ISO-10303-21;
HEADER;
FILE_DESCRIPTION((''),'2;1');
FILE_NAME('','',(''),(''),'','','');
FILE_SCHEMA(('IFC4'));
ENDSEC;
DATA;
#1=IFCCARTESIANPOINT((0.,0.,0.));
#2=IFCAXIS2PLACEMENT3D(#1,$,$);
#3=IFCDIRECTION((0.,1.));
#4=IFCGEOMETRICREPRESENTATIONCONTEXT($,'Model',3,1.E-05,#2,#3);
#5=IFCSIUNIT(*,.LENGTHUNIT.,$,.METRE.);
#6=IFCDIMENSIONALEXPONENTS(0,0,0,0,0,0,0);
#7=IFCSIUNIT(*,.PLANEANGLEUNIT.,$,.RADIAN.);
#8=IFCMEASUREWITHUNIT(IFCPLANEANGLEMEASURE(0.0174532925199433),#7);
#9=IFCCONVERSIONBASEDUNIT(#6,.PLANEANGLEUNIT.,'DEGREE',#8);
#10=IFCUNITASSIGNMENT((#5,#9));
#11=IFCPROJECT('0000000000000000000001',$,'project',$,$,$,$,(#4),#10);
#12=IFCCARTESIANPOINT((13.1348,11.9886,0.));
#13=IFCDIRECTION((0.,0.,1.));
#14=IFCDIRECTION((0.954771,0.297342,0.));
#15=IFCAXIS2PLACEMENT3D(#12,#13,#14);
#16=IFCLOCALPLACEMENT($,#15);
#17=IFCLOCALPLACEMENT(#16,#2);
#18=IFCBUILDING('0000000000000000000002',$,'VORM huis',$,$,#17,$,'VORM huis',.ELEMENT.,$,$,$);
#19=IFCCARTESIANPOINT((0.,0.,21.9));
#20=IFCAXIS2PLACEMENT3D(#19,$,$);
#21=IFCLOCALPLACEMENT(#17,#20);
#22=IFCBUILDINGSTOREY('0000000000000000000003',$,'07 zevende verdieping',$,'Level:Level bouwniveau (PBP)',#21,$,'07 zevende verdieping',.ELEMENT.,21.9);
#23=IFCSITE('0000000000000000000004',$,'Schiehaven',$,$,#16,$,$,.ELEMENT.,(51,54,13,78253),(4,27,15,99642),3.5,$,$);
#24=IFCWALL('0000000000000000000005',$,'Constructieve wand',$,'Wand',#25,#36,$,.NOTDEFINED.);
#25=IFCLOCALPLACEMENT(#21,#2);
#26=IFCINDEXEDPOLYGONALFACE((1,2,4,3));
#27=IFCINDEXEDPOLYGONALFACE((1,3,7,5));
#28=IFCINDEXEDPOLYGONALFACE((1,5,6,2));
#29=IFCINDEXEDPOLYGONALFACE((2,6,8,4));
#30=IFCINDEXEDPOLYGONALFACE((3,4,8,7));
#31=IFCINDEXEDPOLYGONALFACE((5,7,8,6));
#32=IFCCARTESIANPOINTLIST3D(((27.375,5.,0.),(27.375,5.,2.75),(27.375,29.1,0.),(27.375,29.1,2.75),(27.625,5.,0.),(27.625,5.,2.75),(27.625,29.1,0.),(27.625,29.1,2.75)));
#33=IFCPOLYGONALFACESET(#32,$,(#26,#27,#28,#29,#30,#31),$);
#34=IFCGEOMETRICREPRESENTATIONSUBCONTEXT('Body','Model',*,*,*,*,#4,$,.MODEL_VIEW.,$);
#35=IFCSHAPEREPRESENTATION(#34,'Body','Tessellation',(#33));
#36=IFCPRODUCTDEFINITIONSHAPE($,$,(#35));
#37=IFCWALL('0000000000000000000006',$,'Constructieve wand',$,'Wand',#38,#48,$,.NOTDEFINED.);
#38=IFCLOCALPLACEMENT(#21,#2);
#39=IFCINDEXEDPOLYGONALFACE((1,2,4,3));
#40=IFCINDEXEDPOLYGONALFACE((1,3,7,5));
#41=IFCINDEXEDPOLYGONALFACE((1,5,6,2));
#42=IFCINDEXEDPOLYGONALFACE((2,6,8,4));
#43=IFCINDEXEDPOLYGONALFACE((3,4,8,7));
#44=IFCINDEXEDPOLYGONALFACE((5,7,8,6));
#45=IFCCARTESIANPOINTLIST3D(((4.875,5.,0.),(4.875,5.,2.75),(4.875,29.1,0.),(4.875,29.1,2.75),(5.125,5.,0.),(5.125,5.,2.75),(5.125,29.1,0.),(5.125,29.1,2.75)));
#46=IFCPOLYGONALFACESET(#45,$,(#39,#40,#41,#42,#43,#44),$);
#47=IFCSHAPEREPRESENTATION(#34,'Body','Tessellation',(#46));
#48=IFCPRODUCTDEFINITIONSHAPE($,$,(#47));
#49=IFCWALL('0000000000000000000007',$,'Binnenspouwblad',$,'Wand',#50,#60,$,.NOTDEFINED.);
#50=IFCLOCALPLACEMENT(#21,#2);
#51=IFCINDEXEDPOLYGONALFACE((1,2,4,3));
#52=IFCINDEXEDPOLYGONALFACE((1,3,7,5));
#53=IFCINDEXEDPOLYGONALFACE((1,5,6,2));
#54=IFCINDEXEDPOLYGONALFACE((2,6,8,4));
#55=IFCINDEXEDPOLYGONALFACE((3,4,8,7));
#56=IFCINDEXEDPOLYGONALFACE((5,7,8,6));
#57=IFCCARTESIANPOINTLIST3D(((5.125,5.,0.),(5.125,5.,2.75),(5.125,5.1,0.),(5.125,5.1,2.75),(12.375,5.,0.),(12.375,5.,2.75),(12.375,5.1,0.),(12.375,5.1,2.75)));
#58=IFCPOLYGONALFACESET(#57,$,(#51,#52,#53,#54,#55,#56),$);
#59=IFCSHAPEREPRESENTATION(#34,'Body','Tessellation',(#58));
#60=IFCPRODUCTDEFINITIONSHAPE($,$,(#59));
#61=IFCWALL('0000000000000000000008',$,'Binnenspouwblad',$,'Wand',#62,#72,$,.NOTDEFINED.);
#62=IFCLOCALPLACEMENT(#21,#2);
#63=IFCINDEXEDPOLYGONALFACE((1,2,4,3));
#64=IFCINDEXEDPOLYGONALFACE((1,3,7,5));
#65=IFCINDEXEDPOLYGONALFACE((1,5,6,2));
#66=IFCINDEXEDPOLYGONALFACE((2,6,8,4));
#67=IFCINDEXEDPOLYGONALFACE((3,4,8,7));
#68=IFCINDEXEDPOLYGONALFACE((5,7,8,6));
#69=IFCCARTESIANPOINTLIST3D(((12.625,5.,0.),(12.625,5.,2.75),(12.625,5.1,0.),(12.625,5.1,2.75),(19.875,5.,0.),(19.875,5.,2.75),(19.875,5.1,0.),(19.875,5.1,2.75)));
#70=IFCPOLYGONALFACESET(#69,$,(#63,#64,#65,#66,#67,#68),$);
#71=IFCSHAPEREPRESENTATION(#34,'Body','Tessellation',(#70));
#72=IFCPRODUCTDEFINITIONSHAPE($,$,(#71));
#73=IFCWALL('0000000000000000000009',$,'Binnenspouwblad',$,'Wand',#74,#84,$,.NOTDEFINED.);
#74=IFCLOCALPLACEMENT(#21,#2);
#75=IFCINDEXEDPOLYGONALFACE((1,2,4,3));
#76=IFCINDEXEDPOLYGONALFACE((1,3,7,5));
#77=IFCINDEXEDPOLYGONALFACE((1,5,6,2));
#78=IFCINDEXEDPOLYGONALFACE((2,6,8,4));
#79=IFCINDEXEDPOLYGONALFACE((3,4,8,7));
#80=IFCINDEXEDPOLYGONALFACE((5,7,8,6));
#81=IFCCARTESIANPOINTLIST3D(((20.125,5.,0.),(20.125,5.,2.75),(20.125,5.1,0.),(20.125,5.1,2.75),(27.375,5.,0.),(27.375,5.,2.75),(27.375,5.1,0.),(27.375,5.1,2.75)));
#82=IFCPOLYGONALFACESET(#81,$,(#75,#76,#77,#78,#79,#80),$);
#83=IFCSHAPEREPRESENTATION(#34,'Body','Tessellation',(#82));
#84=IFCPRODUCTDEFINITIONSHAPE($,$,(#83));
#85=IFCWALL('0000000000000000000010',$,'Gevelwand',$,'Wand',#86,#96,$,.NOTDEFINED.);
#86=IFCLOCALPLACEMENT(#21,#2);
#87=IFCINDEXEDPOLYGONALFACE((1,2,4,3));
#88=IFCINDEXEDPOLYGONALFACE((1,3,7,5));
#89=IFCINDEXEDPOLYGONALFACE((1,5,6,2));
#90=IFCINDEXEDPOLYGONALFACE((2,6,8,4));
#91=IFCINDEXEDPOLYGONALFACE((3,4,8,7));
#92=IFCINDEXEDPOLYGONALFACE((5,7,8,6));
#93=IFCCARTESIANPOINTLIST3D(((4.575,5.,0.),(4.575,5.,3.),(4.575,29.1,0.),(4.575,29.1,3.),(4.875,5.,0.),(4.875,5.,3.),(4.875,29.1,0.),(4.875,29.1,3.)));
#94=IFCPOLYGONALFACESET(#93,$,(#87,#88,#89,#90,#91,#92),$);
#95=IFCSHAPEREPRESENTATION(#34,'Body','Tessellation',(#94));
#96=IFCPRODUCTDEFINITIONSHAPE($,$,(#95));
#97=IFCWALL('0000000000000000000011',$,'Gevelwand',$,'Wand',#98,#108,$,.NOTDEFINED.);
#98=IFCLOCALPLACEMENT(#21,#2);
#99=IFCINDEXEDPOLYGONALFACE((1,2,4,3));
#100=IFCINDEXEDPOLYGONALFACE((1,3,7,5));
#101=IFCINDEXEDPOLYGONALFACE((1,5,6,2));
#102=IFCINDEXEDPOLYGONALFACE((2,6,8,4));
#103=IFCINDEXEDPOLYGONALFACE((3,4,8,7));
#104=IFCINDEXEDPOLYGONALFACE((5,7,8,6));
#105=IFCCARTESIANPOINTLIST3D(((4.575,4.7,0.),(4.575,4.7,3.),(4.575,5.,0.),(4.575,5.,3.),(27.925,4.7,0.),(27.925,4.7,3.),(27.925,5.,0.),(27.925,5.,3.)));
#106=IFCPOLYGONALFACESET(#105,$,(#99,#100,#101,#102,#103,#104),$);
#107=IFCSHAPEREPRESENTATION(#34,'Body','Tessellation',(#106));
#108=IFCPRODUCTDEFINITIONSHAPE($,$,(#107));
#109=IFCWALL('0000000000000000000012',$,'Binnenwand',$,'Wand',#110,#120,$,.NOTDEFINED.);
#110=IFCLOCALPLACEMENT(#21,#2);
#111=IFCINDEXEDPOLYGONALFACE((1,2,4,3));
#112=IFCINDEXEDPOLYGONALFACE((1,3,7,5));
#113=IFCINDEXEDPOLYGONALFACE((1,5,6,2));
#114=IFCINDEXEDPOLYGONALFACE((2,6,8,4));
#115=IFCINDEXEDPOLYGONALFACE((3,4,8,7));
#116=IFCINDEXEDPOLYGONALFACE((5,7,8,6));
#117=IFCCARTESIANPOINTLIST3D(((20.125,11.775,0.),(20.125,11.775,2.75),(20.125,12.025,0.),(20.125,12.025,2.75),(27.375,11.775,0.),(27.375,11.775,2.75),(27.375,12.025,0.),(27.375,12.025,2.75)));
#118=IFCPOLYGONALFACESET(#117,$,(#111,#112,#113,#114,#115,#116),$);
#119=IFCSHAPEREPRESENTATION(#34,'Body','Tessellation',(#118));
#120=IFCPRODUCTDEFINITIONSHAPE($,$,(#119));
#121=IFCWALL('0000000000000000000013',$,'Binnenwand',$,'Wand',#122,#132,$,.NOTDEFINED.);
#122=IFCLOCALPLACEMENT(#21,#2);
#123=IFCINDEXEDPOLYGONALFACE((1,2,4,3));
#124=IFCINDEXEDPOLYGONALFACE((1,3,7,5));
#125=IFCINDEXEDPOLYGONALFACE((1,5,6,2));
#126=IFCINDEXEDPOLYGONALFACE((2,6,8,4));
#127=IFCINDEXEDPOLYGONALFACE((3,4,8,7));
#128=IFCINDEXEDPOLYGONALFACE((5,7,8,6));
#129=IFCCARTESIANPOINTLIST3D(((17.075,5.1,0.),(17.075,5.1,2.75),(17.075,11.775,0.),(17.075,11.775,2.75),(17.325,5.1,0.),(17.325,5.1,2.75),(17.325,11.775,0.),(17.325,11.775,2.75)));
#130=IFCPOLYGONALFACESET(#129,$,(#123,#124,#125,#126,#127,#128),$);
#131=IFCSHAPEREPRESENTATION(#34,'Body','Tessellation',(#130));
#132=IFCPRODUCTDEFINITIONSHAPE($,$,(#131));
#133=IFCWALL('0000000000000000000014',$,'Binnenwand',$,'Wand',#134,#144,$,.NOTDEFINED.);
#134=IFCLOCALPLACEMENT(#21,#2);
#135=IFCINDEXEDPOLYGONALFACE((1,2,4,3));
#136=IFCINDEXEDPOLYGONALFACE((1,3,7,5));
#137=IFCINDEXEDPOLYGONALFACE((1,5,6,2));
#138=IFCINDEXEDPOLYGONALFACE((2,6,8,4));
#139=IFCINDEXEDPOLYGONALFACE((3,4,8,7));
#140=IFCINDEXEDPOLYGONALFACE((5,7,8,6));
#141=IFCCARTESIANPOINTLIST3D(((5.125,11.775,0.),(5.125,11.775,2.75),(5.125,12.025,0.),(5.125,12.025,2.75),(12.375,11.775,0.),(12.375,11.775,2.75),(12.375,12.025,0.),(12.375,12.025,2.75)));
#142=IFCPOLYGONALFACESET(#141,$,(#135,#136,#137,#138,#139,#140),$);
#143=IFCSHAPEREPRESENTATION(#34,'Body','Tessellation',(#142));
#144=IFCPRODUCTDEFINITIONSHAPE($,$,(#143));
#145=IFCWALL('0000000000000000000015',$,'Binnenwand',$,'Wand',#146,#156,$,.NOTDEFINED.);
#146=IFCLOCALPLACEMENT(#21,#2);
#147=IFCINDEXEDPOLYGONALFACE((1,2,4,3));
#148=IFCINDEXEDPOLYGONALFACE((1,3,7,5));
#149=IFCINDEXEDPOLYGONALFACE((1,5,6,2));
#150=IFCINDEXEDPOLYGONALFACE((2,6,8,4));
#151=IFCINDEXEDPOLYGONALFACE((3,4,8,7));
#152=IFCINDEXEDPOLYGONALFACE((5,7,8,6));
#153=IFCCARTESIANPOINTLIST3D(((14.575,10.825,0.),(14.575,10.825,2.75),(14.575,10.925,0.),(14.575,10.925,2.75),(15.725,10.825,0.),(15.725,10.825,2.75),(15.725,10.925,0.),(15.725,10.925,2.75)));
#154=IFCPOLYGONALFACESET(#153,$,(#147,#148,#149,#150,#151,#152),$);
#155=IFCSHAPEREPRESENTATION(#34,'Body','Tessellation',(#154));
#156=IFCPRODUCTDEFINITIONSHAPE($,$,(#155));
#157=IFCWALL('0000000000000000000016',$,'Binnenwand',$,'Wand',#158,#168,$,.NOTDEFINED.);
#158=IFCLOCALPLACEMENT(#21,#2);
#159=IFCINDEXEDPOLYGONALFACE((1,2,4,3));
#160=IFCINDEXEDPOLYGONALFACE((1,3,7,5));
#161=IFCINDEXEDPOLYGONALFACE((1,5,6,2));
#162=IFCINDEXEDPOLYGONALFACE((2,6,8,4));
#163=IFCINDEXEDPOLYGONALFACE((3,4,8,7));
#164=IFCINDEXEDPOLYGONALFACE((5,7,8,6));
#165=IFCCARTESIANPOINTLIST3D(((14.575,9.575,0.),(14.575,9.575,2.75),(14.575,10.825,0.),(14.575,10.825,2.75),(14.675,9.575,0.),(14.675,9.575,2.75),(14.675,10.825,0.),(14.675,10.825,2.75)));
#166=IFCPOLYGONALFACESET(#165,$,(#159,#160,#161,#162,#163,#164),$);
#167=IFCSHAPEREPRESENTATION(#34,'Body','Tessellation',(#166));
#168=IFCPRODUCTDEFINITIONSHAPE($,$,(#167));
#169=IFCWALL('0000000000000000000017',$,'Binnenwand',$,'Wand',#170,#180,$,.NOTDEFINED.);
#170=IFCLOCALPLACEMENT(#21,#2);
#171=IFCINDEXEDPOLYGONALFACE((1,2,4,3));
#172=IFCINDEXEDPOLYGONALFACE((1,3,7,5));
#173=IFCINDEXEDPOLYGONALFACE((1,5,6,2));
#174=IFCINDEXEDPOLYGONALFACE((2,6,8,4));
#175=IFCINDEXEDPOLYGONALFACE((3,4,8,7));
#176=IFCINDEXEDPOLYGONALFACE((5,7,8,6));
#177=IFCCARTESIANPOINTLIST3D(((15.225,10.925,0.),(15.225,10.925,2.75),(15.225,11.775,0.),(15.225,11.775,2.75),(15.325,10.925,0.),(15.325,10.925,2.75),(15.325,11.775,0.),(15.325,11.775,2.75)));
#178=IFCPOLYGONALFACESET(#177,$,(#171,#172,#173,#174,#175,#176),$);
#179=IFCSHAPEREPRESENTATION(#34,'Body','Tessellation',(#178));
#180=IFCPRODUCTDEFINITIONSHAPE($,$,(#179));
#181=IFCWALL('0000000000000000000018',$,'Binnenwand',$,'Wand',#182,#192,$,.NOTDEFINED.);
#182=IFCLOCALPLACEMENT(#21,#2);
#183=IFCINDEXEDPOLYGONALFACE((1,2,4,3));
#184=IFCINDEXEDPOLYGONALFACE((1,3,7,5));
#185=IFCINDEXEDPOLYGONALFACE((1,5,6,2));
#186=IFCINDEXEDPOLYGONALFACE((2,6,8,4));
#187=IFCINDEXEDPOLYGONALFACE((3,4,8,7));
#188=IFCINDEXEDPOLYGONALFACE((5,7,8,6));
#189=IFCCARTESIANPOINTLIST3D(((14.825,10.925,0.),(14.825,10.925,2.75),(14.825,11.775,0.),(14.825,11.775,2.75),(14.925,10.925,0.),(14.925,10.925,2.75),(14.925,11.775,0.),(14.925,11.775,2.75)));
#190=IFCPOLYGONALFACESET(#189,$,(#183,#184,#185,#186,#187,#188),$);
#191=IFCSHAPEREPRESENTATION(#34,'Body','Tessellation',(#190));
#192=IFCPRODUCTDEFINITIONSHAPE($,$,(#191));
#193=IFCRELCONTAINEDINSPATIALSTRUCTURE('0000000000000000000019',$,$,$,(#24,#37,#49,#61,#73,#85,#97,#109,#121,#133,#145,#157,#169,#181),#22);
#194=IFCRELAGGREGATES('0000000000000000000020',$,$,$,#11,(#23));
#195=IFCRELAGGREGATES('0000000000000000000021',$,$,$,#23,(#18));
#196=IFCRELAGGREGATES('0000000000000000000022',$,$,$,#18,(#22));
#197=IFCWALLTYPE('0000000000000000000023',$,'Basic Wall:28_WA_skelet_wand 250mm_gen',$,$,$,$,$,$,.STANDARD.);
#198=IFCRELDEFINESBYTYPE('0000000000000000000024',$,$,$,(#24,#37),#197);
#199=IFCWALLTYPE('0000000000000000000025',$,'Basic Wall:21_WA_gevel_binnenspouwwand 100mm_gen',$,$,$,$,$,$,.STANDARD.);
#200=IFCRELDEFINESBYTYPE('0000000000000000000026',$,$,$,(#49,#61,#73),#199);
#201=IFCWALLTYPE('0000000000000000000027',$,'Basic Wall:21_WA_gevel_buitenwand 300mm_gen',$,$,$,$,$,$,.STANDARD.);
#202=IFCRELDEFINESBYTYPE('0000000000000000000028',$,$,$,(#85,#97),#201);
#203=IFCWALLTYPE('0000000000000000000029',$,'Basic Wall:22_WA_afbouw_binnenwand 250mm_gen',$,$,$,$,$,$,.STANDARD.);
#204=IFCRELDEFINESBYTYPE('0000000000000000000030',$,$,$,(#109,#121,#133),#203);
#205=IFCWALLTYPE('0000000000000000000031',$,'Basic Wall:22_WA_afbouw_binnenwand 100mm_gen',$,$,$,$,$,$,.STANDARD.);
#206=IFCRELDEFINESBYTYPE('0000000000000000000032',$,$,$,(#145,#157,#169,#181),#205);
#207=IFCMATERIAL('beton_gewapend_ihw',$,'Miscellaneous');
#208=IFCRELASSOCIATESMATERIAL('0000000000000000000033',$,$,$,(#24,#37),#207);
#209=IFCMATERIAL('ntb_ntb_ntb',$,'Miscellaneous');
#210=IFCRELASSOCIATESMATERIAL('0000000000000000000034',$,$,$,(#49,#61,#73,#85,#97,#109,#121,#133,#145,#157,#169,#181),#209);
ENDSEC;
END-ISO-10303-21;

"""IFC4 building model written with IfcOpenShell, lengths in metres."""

from ifc_helpers import new_model, entity, si_unit, converted_unit, direction, frame, origin, place, context, subcontext, project, spatial, indexed_curve, outline, extrude, material, type_object, element, save


model = new_model("IFC4")

# Units and contexts
model_context = context("Model", 3, precision=1e-05, world=origin(), true_north=direction((0.0, 1.0)))
body_context = subcontext(model_context, "Body", "Model", "MODEL_VIEW")
ifc_project = project(units=[si_unit("LENGTHUNIT", "METRE"), converted_unit("PLANEANGLEUNIT", "DEGREE", entity("IfcPlaneAngleMeasure", 0.0174532925199433), si_unit("PLANEANGLEUNIT", "RADIAN"), dimensions=[0, 0, 0, 0, 0, 0, 0])], contexts=[model_context])

# Site, building, storey
site_placement = place(None, frame((13.1348, 11.9886, 0.0), z_axis=(0.0, 0.0, 1.0), x_axis=(0.954771, 0.297342, 0.0)))
site = spatial("IfcSite", under=ifc_project, at=site_placement, Name="Schiehaven", CompositionType="ELEMENT", RefLatitude=(51, 54, 13, 78253), RefLongitude=(4, 27, 15, 99642), RefElevation=3.5)
building_placement = place(site_placement, origin())
building = spatial("IfcBuilding", under=site, at=building_placement, Name="VORM huis", LongName="VORM huis", CompositionType="ELEMENT")
storey_placement = place(building_placement, frame((0.0, 0.0, 21.9)))
storey = spatial("IfcBuildingStorey", under=building, at=storey_placement, Name="07 zevende verdieping", ObjectType="Level:Level bouwniveau (PBP)", LongName="07 zevende verdieping", CompositionType="ELEMENT", Elevation=21.9)

# Shared definitions
ifc_material_1 = material(Name="beton_gewapend_ihw", Category="Miscellaneous")

# Walls
wall_type_1 = type_object("IfcWallType", Name="Basic Wall:28_WA_skelet_wand 250mm_gen", PredefinedType="STANDARD")
wall_1_placement = place(storey_placement, frame((27.5, 5.0, 0.0), z_axis=(0.0, 0.0, 1.0), x_axis=(0.0, 1.0, 0.0)))
element("IfcWall", 1, at=wall_1_placement, inside=storey, type_object=wall_type_1, material=ifc_material_1, Name="Constructieve wand", ObjectType="Wand", PredefinedType="NOTDEFINED", context=body_context, shape_type="SweptSolid", body=[
    extrude(outline(indexed_curve([(24.1, 0.125), (0.0, 0.125), (0.0, -0.125), (24.1, -0.125), (24.1, 0.125)], self_intersect=False)), origin(), (0.0, 0.0, 1.0), 2.75),
])
wall_2_placement = place(storey_placement, frame((5.0, 5.0, 0.0), z_axis=(0.0, 0.0, 1.0), x_axis=(0.0, 1.0, 0.0)))
element("IfcWall", 2, at=wall_2_placement, inside=storey, type_object=wall_type_1, material=ifc_material_1, Name="Constructieve wand", ObjectType="Wand", PredefinedType="NOTDEFINED", context=body_context, shape_type="SweptSolid", body=[
    extrude(outline(indexed_curve([(24.1, 0.125), (0.0, 0.125), (0.0, -0.125), (24.1, -0.125), (24.1, 0.125)], self_intersect=False)), origin(), (0.0, 0.0, 1.0), 2.75),
])
ifc_material_2 = material(Name="ntb_ntb_ntb", Category="Miscellaneous")
wall_type_2 = type_object("IfcWallType", Name="Basic Wall:21_WA_gevel_binnenspouwwand 100mm_gen", PredefinedType="STANDARD")
wall_3_placement = place(storey_placement, frame((5.125, 5.05, 0.0)))
element("IfcWall", 3, at=wall_3_placement, inside=storey, type_object=wall_type_2, material=ifc_material_2, Name="Binnenspouwblad", ObjectType="Wand", PredefinedType="NOTDEFINED", context=body_context, shape_type="SweptSolid", body=[
    extrude(outline(indexed_curve([(7.25, 0.05), (0.0, 0.05), (0.0, -0.05), (7.25, -0.05), (7.25, 0.05)], self_intersect=False)), origin(), (0.0, 0.0, 1.0), 2.75),
])
wall_4_placement = place(storey_placement, frame((19.875, 5.05, 0.0), z_axis=(0.0, 0.0, 1.0), x_axis=(-1.0, 0.0, 0.0)))
element("IfcWall", 4, at=wall_4_placement, inside=storey, type_object=wall_type_2, material=ifc_material_2, Name="Binnenspouwblad", ObjectType="Wand", PredefinedType="NOTDEFINED", context=body_context, shape_type="SweptSolid", body=[
    extrude(outline(indexed_curve([(7.25, 0.05), (0.0, 0.05), (0.0, -0.05), (7.25, -0.05), (7.25, 0.05)], self_intersect=False)), origin(), (0.0, 0.0, 1.0), 2.75),
])
wall_5_placement = place(storey_placement, frame((20.125, 5.05, 0.0)))
element("IfcWall", 5, at=wall_5_placement, inside=storey, type_object=wall_type_2, material=ifc_material_2, Name="Binnenspouwblad", ObjectType="Wand", PredefinedType="NOTDEFINED", context=body_context, shape_type="SweptSolid", body=[
    extrude(outline(indexed_curve([(7.25, 0.05), (0.0, 0.05), (0.0, -0.05), (7.25, -0.05), (7.25, 0.05)], self_intersect=False)), origin(), (0.0, 0.0, 1.0), 2.75),
])
wall_type_3 = type_object("IfcWallType", Name="Basic Wall:21_WA_gevel_buitenwand 300mm_gen", PredefinedType="STANDARD")
wall_6_placement = place(storey_placement, frame((4.725, 5.0, 0.0), z_axis=(0.0, 0.0, 1.0), x_axis=(0.0, 1.0, 0.0)))
element("IfcWall", 6, at=wall_6_placement, inside=storey, type_object=wall_type_3, material=ifc_material_2, Name="Gevelwand", ObjectType="Wand", PredefinedType="NOTDEFINED", context=body_context, shape_type="SweptSolid", body=[
    extrude(outline(indexed_curve([(24.1, 0.15), (0.0, 0.15), (0.0, -0.15), (24.1, -0.15), (24.1, 0.15)], self_intersect=False)), origin(), (0.0, 0.0, 1.0), 3.0),
])
wall_7_placement = place(storey_placement, frame((27.925, 4.85, 0.0), z_axis=(0.0, 0.0, 1.0), x_axis=(-1.0, 0.0, 0.0)))
element("IfcWall", 7, at=wall_7_placement, inside=storey, type_object=wall_type_3, material=ifc_material_2, Name="Gevelwand", ObjectType="Wand", PredefinedType="NOTDEFINED", context=body_context, shape_type="SweptSolid", body=[
    extrude(outline(indexed_curve([(23.35, 0.15), (0.0, 0.15), (0.0, -0.15), (23.35, -0.15), (23.35, 0.15)], self_intersect=False)), origin(), (0.0, 0.0, 1.0), 3.0),
])
wall_type_4 = type_object("IfcWallType", Name="Basic Wall:22_WA_afbouw_binnenwand 250mm_gen", PredefinedType="STANDARD")
wall_8_placement = place(storey_placement, frame((20.125, 11.9, 0.0)))
element("IfcWall", 8, at=wall_8_placement, inside=storey, type_object=wall_type_4, material=ifc_material_2, Name="Binnenwand", ObjectType="Wand", PredefinedType="NOTDEFINED", context=body_context, shape_type="SweptSolid", body=[
    extrude(outline(indexed_curve([(7.25, 0.125), (0.0, 0.125), (0.0, -0.125), (7.25, -0.125), (7.25, 0.125)], self_intersect=False)), origin(), (0.0, 0.0, 1.0), 2.75),
])
wall_9_placement = place(storey_placement, frame((17.2, 11.775, 0.0), z_axis=(0.0, 0.0, 1.0), x_axis=(0.0, -1.0, 0.0)))
element("IfcWall", 9, at=wall_9_placement, inside=storey, type_object=wall_type_4, material=ifc_material_2, Name="Binnenwand", ObjectType="Wand", PredefinedType="NOTDEFINED", context=body_context, shape_type="SweptSolid", body=[
    extrude(outline(indexed_curve([(6.675, 0.125), (0.0, 0.125), (0.0, -0.125), (6.675, -0.125), (6.675, 0.125)], self_intersect=False)), origin(), (0.0, 0.0, 1.0), 2.75),
])
wall_10_placement = place(storey_placement, frame((12.375, 11.9, 0.0), z_axis=(0.0, 0.0, 1.0), x_axis=(-1.0, 0.0, 0.0)))
element("IfcWall", 10, at=wall_10_placement, inside=storey, type_object=wall_type_4, material=ifc_material_2, Name="Binnenwand", ObjectType="Wand", PredefinedType="NOTDEFINED", context=body_context, shape_type="SweptSolid", body=[
    extrude(outline(indexed_curve([(7.25, 0.125), (0.0, 0.125), (0.0, -0.125), (7.25, -0.125), (7.25, 0.125)], self_intersect=False)), origin(), (0.0, 0.0, 1.0), 2.75),
])
wall_type_5 = type_object("IfcWallType", Name="Basic Wall:22_WA_afbouw_binnenwand 100mm_gen", PredefinedType="STANDARD")
wall_11_placement = place(storey_placement, frame((14.575, 10.875, 0.0)))
element("IfcWall", 11, at=wall_11_placement, inside=storey, type_object=wall_type_5, material=ifc_material_2, Name="Binnenwand", ObjectType="Wand", PredefinedType="NOTDEFINED", context=body_context, shape_type="SweptSolid", body=[
    extrude(outline(indexed_curve([(1.15, 0.05), (0.0, 0.05), (0.0, -0.05), (1.15, -0.05), (1.15, 0.05)], self_intersect=False)), origin(), (0.0, 0.0, 1.0), 2.75),
])
wall_12_placement = place(storey_placement, frame((14.625, 10.825, 0.0), z_axis=(0.0, 0.0, 1.0), x_axis=(0.0, -1.0, 0.0)))
element("IfcWall", 12, at=wall_12_placement, inside=storey, type_object=wall_type_5, material=ifc_material_2, Name="Binnenwand", ObjectType="Wand", PredefinedType="NOTDEFINED", context=body_context, shape_type="SweptSolid", body=[
    extrude(outline(indexed_curve([(1.25, 0.05), (0.0, 0.05), (0.0, -0.05), (1.25, -0.05), (1.25, 0.05)], self_intersect=False)), origin(), (0.0, 0.0, 1.0), 2.75),
])
wall_13_placement = place(storey_placement, frame((15.275, 11.775, 0.0), z_axis=(0.0, 0.0, 1.0), x_axis=(0.0, -1.0, 0.0)))
element("IfcWall", 13, at=wall_13_placement, inside=storey, type_object=wall_type_5, material=ifc_material_2, Name="Binnenwand", ObjectType="Wand", PredefinedType="NOTDEFINED", context=body_context, shape_type="SweptSolid", body=[
    extrude(outline(indexed_curve([(0.85, 0.05), (0.0, 0.05), (0.0, -0.05), (0.85, -0.05), (0.85, 0.05)], self_intersect=False)), origin(), (0.0, 0.0, 1.0), 2.75),
])
wall_14_placement = place(storey_placement, frame((14.875, 11.775, 0.0), z_axis=(0.0, 0.0, 1.0), x_axis=(0.0, -1.0, 0.0)))
element("IfcWall", 14, at=wall_14_placement, inside=storey, type_object=wall_type_5, material=ifc_material_2, Name="Binnenwand", ObjectType="Wand", PredefinedType="NOTDEFINED", context=body_context, shape_type="SweptSolid", body=[
    extrude(outline(indexed_curve([(0.85, 0.05), (0.0, 0.05), (0.0, -0.05), (0.85, -0.05), (0.85, 0.05)], self_intersect=False)), origin(), (0.0, 0.0, 1.0), 2.75),
])

save(model, "model.ifc")
